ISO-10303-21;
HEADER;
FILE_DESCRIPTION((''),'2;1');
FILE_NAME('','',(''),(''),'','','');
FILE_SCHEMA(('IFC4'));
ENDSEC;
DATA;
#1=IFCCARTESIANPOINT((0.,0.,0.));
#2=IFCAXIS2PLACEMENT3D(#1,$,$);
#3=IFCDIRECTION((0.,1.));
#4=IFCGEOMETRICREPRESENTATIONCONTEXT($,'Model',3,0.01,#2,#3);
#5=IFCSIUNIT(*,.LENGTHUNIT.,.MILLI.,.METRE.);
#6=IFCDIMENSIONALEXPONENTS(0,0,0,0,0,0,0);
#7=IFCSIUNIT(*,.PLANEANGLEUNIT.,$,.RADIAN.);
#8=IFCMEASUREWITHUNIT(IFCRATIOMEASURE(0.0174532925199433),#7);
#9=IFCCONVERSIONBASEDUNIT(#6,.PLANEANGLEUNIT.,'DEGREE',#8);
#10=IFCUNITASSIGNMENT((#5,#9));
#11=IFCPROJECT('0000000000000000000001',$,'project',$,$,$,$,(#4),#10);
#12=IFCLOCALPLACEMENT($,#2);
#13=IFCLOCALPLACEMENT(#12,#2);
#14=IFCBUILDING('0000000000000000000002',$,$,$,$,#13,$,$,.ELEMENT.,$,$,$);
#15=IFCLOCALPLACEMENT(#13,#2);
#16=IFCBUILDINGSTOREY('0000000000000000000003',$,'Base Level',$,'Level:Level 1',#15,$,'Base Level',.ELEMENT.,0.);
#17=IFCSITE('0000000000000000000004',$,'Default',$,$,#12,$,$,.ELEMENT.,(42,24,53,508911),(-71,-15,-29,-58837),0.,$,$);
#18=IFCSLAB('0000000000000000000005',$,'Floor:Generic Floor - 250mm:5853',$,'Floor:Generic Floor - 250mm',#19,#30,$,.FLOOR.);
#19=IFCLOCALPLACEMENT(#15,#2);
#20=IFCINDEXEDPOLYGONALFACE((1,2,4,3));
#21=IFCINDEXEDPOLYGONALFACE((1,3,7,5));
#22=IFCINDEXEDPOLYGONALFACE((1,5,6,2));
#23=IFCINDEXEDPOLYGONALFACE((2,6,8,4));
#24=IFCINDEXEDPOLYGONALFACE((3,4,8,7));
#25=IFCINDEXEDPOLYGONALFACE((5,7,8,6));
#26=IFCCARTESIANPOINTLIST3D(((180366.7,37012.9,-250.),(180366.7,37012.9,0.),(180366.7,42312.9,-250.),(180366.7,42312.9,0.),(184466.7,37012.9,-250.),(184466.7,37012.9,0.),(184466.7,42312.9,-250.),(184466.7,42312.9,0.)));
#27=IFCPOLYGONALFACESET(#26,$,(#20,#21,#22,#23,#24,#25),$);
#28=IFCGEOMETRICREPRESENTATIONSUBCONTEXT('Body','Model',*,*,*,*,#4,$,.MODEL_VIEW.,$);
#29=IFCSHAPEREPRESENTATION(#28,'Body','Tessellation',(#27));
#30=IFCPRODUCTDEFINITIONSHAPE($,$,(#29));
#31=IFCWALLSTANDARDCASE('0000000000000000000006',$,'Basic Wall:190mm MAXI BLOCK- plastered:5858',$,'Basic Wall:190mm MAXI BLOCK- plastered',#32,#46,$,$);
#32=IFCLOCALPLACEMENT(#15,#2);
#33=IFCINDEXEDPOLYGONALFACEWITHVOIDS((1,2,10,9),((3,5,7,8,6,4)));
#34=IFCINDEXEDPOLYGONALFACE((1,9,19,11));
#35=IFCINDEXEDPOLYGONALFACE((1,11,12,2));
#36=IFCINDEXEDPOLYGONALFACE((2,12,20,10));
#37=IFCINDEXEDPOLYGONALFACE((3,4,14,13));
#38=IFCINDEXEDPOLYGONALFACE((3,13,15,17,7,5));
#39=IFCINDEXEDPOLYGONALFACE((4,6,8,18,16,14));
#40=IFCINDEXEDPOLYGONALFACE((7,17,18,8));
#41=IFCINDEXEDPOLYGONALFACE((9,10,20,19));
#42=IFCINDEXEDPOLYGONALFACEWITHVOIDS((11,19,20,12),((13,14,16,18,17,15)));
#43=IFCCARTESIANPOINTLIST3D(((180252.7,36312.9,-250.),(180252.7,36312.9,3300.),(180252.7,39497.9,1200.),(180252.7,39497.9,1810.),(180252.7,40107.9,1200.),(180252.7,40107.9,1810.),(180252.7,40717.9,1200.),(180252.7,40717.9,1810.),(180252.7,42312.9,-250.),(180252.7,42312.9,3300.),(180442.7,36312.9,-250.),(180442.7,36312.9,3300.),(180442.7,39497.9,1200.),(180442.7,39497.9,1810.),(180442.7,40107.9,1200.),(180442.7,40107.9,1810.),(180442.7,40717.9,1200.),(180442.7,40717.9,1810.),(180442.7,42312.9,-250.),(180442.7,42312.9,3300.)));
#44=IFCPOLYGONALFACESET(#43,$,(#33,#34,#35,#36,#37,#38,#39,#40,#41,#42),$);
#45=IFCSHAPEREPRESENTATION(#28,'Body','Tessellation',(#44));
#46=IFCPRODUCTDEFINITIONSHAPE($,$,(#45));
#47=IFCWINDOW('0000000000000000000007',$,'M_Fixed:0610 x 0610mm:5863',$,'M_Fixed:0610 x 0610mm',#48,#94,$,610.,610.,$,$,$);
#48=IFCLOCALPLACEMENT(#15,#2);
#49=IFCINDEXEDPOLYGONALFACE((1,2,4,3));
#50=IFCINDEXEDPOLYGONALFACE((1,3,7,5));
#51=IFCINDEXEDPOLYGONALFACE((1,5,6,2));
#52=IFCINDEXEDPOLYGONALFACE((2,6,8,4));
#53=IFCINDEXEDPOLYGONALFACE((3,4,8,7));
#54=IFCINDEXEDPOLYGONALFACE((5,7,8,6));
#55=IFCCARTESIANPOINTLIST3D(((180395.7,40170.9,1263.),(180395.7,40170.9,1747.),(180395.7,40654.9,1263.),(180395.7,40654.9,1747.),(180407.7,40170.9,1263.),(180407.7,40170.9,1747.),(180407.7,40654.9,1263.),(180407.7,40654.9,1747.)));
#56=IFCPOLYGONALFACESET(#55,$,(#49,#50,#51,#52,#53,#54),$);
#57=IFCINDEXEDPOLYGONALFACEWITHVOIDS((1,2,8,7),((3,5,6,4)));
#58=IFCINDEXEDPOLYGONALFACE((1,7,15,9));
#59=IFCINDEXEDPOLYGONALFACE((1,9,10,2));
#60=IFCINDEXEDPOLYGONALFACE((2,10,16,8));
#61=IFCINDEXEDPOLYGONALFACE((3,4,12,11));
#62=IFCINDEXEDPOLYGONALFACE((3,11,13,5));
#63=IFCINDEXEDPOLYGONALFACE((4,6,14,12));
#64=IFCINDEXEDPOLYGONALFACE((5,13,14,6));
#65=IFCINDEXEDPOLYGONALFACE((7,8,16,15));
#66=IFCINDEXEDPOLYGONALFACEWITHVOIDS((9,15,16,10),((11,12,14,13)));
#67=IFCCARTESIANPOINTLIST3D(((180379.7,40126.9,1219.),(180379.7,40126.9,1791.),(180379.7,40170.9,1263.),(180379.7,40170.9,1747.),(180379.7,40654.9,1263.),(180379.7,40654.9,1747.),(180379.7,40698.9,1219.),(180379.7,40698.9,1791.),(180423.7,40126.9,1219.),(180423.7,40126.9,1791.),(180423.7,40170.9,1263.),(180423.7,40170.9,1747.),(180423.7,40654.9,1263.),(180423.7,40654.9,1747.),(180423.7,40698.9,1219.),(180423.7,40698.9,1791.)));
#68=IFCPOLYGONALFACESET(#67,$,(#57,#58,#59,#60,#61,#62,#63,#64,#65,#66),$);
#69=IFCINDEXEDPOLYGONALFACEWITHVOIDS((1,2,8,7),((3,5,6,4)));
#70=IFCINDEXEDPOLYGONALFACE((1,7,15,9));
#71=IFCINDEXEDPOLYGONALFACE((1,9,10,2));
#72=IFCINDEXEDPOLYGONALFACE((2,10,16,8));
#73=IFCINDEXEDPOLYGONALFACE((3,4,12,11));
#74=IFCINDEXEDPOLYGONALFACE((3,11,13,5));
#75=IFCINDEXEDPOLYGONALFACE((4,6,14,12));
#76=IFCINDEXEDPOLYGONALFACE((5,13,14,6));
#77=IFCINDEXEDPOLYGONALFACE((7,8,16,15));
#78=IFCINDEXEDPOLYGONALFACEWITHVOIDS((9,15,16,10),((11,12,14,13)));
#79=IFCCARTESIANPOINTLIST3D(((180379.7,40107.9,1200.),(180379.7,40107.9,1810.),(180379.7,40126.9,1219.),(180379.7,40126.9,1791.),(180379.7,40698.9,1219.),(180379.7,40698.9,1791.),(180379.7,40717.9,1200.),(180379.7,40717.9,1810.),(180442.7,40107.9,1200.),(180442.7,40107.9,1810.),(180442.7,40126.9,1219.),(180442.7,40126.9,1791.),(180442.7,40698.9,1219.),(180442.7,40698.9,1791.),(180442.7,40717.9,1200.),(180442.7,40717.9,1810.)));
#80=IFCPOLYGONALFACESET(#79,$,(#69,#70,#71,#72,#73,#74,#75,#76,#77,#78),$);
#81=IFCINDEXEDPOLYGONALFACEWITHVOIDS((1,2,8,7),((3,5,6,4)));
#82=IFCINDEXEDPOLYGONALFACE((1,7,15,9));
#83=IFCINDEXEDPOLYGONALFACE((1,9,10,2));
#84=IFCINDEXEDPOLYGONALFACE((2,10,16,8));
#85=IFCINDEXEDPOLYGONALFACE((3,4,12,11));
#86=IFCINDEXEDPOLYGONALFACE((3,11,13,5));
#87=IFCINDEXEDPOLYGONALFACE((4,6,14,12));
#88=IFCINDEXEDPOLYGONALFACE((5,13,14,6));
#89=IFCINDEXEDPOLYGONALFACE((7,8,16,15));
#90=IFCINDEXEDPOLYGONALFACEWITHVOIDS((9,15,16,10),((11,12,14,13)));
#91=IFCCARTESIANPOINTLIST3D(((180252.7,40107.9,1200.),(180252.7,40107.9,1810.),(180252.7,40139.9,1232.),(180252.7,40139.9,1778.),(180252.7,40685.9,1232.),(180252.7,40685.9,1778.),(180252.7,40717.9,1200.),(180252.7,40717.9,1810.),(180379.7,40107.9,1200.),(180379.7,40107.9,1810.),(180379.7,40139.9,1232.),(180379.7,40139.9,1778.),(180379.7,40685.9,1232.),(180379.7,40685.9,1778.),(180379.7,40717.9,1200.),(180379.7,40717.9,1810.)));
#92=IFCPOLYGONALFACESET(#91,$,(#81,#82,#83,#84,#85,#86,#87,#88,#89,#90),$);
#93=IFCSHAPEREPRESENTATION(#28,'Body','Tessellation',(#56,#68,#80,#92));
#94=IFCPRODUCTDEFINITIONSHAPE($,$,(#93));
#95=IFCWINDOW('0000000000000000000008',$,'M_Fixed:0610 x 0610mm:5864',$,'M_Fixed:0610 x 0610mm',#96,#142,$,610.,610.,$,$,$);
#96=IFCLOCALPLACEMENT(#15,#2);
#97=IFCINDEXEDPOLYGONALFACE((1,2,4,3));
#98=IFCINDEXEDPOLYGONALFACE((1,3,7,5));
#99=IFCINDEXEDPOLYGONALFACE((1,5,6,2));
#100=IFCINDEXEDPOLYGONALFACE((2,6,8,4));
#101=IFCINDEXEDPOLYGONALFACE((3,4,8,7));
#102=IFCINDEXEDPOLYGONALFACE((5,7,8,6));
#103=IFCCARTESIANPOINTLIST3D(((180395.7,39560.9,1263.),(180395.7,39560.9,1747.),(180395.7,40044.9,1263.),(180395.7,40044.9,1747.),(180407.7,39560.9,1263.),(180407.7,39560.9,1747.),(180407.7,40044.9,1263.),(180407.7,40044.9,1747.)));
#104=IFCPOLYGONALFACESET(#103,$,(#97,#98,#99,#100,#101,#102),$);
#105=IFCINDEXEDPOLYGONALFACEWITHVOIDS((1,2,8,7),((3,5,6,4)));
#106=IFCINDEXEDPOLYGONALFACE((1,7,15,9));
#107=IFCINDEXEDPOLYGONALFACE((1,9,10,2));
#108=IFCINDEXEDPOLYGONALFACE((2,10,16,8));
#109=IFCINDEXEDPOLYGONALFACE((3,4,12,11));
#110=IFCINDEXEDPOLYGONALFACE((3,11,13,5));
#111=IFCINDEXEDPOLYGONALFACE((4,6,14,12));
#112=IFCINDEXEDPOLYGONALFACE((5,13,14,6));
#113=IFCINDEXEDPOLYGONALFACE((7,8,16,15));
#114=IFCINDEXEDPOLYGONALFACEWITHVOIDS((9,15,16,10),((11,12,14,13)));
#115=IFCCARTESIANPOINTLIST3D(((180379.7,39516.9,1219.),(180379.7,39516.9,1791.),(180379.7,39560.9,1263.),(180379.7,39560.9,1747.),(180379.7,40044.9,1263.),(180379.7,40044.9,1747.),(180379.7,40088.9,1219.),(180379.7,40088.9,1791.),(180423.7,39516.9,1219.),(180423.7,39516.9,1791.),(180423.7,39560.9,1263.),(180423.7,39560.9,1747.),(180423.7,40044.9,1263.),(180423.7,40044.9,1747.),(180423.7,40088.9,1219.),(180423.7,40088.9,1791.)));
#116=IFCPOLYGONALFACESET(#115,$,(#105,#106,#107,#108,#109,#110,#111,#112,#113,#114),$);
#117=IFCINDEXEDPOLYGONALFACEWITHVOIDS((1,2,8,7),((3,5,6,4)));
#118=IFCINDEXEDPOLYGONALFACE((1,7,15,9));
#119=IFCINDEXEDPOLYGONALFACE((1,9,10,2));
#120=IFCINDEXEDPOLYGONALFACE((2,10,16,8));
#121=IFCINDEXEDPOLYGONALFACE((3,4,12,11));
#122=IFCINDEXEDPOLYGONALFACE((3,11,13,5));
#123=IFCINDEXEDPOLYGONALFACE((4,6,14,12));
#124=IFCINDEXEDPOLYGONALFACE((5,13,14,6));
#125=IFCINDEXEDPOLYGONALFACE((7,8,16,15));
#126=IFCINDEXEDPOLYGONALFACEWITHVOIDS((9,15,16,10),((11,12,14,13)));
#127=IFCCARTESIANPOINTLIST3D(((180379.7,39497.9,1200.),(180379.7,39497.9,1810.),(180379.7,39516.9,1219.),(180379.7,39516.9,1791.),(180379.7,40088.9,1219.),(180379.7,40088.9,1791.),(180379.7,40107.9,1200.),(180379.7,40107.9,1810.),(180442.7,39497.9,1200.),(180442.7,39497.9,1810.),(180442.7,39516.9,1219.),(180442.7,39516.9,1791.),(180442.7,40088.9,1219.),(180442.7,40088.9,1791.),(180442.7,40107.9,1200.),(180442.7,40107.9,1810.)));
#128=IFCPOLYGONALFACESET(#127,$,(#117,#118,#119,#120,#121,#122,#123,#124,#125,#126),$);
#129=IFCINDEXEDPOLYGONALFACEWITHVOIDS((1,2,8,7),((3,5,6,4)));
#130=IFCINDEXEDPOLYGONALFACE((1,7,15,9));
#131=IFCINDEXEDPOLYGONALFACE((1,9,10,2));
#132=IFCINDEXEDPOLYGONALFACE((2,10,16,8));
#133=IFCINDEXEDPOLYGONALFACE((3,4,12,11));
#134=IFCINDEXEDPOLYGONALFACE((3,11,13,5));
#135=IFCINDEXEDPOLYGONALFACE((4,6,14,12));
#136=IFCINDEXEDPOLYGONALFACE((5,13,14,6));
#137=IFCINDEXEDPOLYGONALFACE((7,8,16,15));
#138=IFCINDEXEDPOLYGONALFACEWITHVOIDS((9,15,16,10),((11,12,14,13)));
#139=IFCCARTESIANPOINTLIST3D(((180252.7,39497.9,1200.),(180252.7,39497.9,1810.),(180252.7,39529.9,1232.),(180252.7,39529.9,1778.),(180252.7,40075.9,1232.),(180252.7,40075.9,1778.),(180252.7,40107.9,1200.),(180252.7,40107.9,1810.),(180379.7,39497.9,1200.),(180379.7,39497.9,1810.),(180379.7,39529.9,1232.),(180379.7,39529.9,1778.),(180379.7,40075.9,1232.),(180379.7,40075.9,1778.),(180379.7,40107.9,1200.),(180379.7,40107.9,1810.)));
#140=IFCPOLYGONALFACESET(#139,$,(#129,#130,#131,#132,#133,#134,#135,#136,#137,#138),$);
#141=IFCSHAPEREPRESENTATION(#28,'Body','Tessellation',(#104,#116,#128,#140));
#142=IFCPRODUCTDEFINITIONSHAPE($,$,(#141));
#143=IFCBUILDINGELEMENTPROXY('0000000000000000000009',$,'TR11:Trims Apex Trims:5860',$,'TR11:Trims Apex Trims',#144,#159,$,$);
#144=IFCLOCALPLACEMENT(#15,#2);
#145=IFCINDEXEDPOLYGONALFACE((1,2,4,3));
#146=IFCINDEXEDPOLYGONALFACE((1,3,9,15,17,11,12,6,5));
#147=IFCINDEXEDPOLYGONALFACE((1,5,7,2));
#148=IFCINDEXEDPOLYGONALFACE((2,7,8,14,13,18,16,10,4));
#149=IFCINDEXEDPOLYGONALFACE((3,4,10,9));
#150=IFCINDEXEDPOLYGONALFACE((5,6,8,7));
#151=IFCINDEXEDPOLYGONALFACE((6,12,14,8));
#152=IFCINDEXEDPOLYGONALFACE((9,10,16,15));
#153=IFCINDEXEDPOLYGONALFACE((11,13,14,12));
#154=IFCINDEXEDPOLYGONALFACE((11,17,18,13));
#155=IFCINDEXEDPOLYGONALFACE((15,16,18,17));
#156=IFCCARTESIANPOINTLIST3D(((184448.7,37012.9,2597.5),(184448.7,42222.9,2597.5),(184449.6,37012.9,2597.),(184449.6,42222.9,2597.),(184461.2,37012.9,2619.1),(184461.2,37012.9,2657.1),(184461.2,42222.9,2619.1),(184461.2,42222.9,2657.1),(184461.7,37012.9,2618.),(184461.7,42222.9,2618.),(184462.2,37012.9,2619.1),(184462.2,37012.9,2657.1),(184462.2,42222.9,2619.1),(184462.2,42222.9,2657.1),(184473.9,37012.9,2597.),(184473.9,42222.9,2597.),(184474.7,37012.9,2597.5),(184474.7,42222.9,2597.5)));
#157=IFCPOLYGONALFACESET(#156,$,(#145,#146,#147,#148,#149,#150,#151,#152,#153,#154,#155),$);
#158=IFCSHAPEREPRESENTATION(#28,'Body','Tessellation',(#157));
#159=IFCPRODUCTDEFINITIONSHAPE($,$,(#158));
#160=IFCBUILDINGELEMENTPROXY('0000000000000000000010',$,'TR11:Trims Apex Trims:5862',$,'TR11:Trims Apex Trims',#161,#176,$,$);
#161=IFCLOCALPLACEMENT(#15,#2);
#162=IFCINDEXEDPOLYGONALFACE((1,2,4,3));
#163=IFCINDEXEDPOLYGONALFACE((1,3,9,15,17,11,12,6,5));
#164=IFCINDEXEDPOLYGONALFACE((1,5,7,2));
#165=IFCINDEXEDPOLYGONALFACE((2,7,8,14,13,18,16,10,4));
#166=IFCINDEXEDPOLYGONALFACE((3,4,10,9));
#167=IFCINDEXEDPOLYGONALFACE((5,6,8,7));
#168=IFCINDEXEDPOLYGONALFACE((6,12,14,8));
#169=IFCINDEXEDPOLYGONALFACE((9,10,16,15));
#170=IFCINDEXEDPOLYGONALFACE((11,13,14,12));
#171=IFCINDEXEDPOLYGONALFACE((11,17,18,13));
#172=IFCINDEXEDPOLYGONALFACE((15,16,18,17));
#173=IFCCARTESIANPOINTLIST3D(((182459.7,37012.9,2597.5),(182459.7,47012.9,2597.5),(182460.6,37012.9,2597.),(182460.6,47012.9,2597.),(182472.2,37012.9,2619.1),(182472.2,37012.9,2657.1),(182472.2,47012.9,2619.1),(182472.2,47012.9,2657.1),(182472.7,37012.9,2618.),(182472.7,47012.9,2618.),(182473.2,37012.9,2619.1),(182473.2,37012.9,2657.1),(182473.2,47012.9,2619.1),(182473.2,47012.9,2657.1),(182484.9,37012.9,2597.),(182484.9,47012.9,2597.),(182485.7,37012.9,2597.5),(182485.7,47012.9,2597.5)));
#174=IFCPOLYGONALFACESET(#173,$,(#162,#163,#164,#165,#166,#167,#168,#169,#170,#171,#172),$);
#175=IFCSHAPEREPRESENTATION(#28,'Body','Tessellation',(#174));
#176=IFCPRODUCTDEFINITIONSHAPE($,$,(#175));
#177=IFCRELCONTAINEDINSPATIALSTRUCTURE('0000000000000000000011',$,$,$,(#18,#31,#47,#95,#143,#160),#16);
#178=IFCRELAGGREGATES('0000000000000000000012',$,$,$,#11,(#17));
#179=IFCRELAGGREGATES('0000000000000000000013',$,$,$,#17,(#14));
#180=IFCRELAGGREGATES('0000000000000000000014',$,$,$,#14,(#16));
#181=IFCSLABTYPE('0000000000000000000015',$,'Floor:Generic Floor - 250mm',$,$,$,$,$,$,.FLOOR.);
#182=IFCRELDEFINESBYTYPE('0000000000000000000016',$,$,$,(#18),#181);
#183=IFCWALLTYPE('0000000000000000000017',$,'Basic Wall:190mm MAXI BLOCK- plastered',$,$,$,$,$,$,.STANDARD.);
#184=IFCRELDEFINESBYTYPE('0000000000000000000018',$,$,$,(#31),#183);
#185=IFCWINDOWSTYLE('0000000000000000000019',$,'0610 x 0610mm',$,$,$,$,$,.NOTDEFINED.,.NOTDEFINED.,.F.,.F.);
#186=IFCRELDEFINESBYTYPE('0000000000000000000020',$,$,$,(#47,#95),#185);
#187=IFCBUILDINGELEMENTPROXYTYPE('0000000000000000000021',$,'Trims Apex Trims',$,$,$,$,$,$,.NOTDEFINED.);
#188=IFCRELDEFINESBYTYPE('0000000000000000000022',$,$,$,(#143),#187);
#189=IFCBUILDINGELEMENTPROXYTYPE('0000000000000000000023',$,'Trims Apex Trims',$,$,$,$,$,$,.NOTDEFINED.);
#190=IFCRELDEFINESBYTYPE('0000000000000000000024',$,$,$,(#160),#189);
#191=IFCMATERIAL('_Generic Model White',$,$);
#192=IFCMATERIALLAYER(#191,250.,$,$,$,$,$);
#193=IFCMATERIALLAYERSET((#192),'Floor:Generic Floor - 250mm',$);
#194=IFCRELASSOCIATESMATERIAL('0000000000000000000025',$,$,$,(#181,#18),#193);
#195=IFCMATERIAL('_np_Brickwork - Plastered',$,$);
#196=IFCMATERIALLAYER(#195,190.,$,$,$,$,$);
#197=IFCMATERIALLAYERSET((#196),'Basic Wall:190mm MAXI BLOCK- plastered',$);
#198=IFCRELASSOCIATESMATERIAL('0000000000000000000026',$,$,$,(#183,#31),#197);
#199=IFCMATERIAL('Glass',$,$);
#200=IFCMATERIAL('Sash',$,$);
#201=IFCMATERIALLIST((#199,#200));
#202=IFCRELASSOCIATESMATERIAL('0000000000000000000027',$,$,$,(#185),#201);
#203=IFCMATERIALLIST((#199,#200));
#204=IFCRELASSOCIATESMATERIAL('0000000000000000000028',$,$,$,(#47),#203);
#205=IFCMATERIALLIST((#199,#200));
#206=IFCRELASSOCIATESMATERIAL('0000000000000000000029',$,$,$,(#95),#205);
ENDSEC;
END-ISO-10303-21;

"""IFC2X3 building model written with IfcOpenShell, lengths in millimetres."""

from ifc_helpers import new_model, entity, si_unit, converted_unit, direction, frame, frame_2d, origin, place, context, subcontext, project, spatial, polyline, rectangle, outline, extrude, source, transform, mapped, material, material_list, layer, layer_set, layer_usage, type_object, type_shapes, element, fill, save


model = new_model("IFC2X3")

# Units and contexts
model_context = context("Model", 3, precision=0.01, world=origin(), true_north=direction((0.0, 1.0)))
body_context = subcontext(model_context, "Body", "Model", "MODEL_VIEW")
ifc_project = project(units=[si_unit("LENGTHUNIT", "METRE", prefix="MILLI"), converted_unit("PLANEANGLEUNIT", "DEGREE", entity("IfcRatioMeasure", 0.0174532925199433), si_unit("PLANEANGLEUNIT", "RADIAN"), dimensions=[0, 0, 0, 0, 0, 0, 0])], contexts=[model_context])

# Site, building, storey
site_placement = place(None, origin())
site = spatial("IfcSite", under=ifc_project, at=site_placement, Name="Default", CompositionType="ELEMENT", RefLatitude=(42, 24, 53, 508911), RefLongitude=(-71, -15, -29, -58837), RefElevation=0.0)
building_placement = place(site_placement, origin())
building = spatial("IfcBuilding", under=site, at=building_placement, CompositionType="ELEMENT")
storey_placement = place(building_placement, origin())
storey = spatial("IfcBuildingStorey", under=building, at=storey_placement, Name="Base Level", ObjectType="Level:Level 1", LongName="Base Level", CompositionType="ELEMENT", Elevation=0.0)

# Slab
ifc_material_1 = material(Name="_Generic Model White")
ifc_layer_1 = layer(ifc_material_1, 250.0)
ifc_layer_set_1 = layer_set([ifc_layer_1], Name="Floor:Generic Floor - 250mm")
ifc_layer_usage_1 = layer_usage(ifc_layer_set_1, "AXIS3", "POSITIVE", 0.0)
slab_type = type_object("IfcSlabType", Name="Floor:Generic Floor - 250mm", PredefinedType="FLOOR", material=ifc_layer_set_1)
slab_placement = place(building_placement, origin())
element("IfcSlab", 1, at=slab_placement, inside=storey, type_object=slab_type, material=ifc_layer_usage_1, Name="Floor:Generic Floor - 250mm:5853", ObjectType="Floor:Generic Floor - 250mm", PredefinedType="FLOOR", context=body_context, shape_type="SweptSolid", body=[
    extrude(rectangle(XDim=5300.0, YDim=4100.0, at=frame_2d((0.0, 0.0), x_axis=(1.0, 0.0))), frame((182416.7, 39662.9, 0.0), z_axis=(0.0, 0.0, -1.0), x_axis=(0.0, 1.0, 0.0)), (0.0, 0.0, 1.0), 250.0),
])

# Wall, openings, windows
ifc_material_2 = material(Name="_np_Brickwork - Plastered")
ifc_layer_2 = layer(ifc_material_2, 190.0)
ifc_layer_set_2 = layer_set([ifc_layer_2], Name="Basic Wall:190mm MAXI BLOCK- plastered")
ifc_layer_usage_2 = layer_usage(ifc_layer_set_2, "AXIS2", "NEGATIVE", 95.0)
wall_type = type_object("IfcWallType", Name="Basic Wall:190mm MAXI BLOCK- plastered", PredefinedType="STANDARD", material=ifc_layer_set_2)
wall_placement = place(building_placement, frame((180347.7, 36312.9, -250.0), z_axis=(0.0, 0.0, 1.0), x_axis=(0.0, 1.0, 0.0)))
wall = element("IfcWallStandardCase", 2, at=wall_placement, inside=storey, type_object=wall_type, material=ifc_layer_usage_2, Name="Basic Wall:190mm MAXI BLOCK- plastered:5858", ObjectType="Basic Wall:190mm MAXI BLOCK- plastered", context=body_context, shape_type="SweptSolid", body=[
    extrude(rectangle(XDim=6000.0, YDim=190.0, at=frame_2d((3000.0, 0.0), x_axis=(-1.0, 0.0))), origin(), (0.0, 0.0, 1.0), 3550.0),
])
opening_1_placement = place(wall_placement, frame((4405.0, 95.0, 1450.0)))
opening_1 = element("IfcOpeningElement", 3, at=opening_1_placement, cuts=wall, ObjectType="Opening", context=body_context, shape_type="SweptSolid", body=[
    extrude(rectangle(XDim=610.0, YDim=610.0, at=frame_2d((305.0, 305.0), x_axis=(1.0, 0.0))), frame((0.0, 0.0, 0.0), z_axis=(0.0, -1.0, 0.0), x_axis=(0.0, 0.0, 1.0)), (0.0, 0.0, 1.0), 190.0),
])
opening_2_placement = place(wall_placement, frame((3795.0, 95.0, 1450.0)))
opening_2 = element("IfcOpeningElement", 4, at=opening_2_placement, cuts=wall, ObjectType="Opening", context=body_context, shape_type="SweptSolid", body=[
    extrude(rectangle(XDim=610.0, YDim=610.0, at=frame_2d((305.0, 305.0), x_axis=(1.0, 0.0))), frame((0.0, 0.0, 0.0), z_axis=(0.0, -1.0, 0.0), x_axis=(0.0, 0.0, 1.0)), (0.0, 0.0, 1.0), 190.0),
])
ifc_material_3 = material(Name="Glass")
ifc_material_4 = material(Name="Sash")
ifc_material_list_1 = material_list([ifc_material_3, ifc_material_4])
ifc_material_list_2 = material_list([ifc_material_3, ifc_material_4])
window_style = type_object("IfcWindowStyle", Name="0610 x 0610mm", ConstructionType="NOTDEFINED", OperationType="NOTDEFINED", ParameterTakesPrecedence=False, Sizeable=False, material=ifc_material_list_2)
shared_shape_1 = source(origin(), body_context, "Body", "SweptSolid", [
    extrude(rectangle(XDim=12.0, YDim=484.0, at=frame_2d((0.0, 0.0), x_axis=(1.0, 0.0))), frame((305.0, 149.0, 63.0), z_axis=(0.0, 0.0, 1.0), x_axis=(0.0, -1.0, 0.0)), (0.0, 0.0, 1.0), 484.0),
    extrude(outline(polyline([(-286.0, -286.0), (286.0, -286.0), (286.0, 286.0), (-286.0, 286.0), (-286.0, -286.0)]), holes=[polyline([(-242.0, -242.0), (-242.0, 242.0), (242.0, 242.0), (242.0, -242.0), (-242.0, -242.0)])]), frame((305.0, 127.0, 305.0), z_axis=(0.0, 1.0, 0.0), x_axis=(1.0, 0.0, 0.0)), (0.0, 0.0, 1.0), 44.0),
    extrude(outline(polyline([(-305.0, -305.0), (305.0, -305.0), (305.0, 305.0), (-305.0, 305.0), (-305.0, -305.0)]), holes=[polyline([(-286.0, -286.0), (-286.0, 286.0), (286.0, 286.0), (286.0, -286.0), (-286.0, -286.0)])]), frame((305.0, 127.0, 305.0), z_axis=(0.0, 1.0, 0.0), x_axis=(1.0, 0.0, 0.0)), (0.0, 0.0, 1.0), 63.0),
    extrude(outline(polyline([(-305.0, -305.0), (305.0, -305.0), (305.0, 305.0), (-305.0, 305.0), (-305.0, -305.0)]), holes=[polyline([(-273.0, -273.0), (-273.0, 273.0), (273.0, 273.0), (273.0, -273.0), (-273.0, -273.0)])]), frame((305.0, 0.0, 305.0), z_axis=(0.0, 1.0, 0.0), x_axis=(1.0, 0.0, 0.0)), (0.0, 0.0, 1.0), 127.0),
])
type_shapes(window_style, [shared_shape_1])
window_1_placement = place(opening_1_placement, frame((0.0, 0.0, 0.0), z_axis=(0.0, 0.0, 1.0), x_axis=(-1.0, 0.0, 0.0)))
window_1 = element("IfcWindow", 5, at=window_1_placement, inside=storey, type_object=window_style, material=ifc_material_list_1, Name="M_Fixed:0610 x 0610mm:5863", ObjectType="M_Fixed:0610 x 0610mm", OverallHeight=610.0, OverallWidth=610.0, context=body_context, shape_type="MappedRepresentation", body=[
    mapped(shared_shape_1, transform((0.0, 0.0, 0.0), scale=1.0)),
])
fill(opening_1, window_1)
ifc_material_list_3 = material_list([ifc_material_3, ifc_material_4])
window_2_placement = place(opening_2_placement, frame((0.0, 0.0, 0.0), z_axis=(0.0, 0.0, 1.0), x_axis=(-1.0, 0.0, 0.0)))
window_2 = element("IfcWindow", 6, at=window_2_placement, inside=storey, type_object=window_style, material=ifc_material_list_3, Name="M_Fixed:0610 x 0610mm:5864", ObjectType="M_Fixed:0610 x 0610mm", OverallHeight=610.0, OverallWidth=610.0, context=body_context, shape_type="MappedRepresentation", body=[
    mapped(shared_shape_1, transform((0.0, 0.0, 0.0), scale=1.0)),
])
fill(opening_2, window_2)

# Building element proxies
building_element_proxy_type_1 = type_object("IfcBuildingElementProxyType", Name="Trims Apex Trims", PredefinedType="NOTDEFINED")
shared_shape_2 = source(origin(), body_context, "Body", "SweptSolid", [
    extrude(outline(polyline([(-39.4, 0.5), (-39.4, -0.5), (-1.4, -0.5), (20.2, -13.0), (20.7, -12.1), (-0.3, 0.0), (20.7, 12.1), (20.2, 13.0), (-1.4, 0.5), (-39.4, 0.5)])), frame((184461.7, 37012.9, 2617.7), z_axis=(0.0, -1.0, 0.0), x_axis=(0.0, 0.0, -1.0)), (0.0, 0.0, -1.0), 5210.0),
])
type_shapes(building_element_proxy_type_1, [shared_shape_2])
proxy_1_placement = place(building_placement, origin())
element("IfcBuildingElementProxy", 7, at=proxy_1_placement, inside=storey, type_object=building_element_proxy_type_1, Name="TR11:Trims Apex Trims:5860", ObjectType="TR11:Trims Apex Trims", context=body_context, shape_type="MappedRepresentation", body=[
    mapped(shared_shape_2, transform((0.0, 0.0, 0.0), scale=1.0)),
])
building_element_proxy_type_2 = type_object("IfcBuildingElementProxyType", Name="Trims Apex Trims", PredefinedType="NOTDEFINED")
shared_shape_3 = source(origin(), body_context, "Body", "SweptSolid", [
    extrude(outline(polyline([(-0.5, -39.4), (0.5, -39.4), (0.5, -1.4), (13.0, 20.2), (12.1, 20.7), (0.0, -0.3), (-12.1, 20.7), (-13.0, 20.2), (-0.5, -1.4), (-0.5, -39.4)])), frame((182472.7, 37012.9, 2617.7), z_axis=(0.0, 1.0, 0.0), x_axis=(1.0, 0.0, 0.0)), (0.0, 0.0, 1.0), 10000.0),
])
type_shapes(building_element_proxy_type_2, [shared_shape_3])
proxy_2_placement = place(building_placement, origin())
element("IfcBuildingElementProxy", 8, at=proxy_2_placement, inside=storey, type_object=building_element_proxy_type_2, Name="TR11:Trims Apex Trims:5862", ObjectType="TR11:Trims Apex Trims", context=body_context, shape_type="MappedRepresentation", body=[
    mapped(shared_shape_3, transform((0.0, 0.0, 0.0), scale=1.0)),
])

save(model, "model.ifc")
